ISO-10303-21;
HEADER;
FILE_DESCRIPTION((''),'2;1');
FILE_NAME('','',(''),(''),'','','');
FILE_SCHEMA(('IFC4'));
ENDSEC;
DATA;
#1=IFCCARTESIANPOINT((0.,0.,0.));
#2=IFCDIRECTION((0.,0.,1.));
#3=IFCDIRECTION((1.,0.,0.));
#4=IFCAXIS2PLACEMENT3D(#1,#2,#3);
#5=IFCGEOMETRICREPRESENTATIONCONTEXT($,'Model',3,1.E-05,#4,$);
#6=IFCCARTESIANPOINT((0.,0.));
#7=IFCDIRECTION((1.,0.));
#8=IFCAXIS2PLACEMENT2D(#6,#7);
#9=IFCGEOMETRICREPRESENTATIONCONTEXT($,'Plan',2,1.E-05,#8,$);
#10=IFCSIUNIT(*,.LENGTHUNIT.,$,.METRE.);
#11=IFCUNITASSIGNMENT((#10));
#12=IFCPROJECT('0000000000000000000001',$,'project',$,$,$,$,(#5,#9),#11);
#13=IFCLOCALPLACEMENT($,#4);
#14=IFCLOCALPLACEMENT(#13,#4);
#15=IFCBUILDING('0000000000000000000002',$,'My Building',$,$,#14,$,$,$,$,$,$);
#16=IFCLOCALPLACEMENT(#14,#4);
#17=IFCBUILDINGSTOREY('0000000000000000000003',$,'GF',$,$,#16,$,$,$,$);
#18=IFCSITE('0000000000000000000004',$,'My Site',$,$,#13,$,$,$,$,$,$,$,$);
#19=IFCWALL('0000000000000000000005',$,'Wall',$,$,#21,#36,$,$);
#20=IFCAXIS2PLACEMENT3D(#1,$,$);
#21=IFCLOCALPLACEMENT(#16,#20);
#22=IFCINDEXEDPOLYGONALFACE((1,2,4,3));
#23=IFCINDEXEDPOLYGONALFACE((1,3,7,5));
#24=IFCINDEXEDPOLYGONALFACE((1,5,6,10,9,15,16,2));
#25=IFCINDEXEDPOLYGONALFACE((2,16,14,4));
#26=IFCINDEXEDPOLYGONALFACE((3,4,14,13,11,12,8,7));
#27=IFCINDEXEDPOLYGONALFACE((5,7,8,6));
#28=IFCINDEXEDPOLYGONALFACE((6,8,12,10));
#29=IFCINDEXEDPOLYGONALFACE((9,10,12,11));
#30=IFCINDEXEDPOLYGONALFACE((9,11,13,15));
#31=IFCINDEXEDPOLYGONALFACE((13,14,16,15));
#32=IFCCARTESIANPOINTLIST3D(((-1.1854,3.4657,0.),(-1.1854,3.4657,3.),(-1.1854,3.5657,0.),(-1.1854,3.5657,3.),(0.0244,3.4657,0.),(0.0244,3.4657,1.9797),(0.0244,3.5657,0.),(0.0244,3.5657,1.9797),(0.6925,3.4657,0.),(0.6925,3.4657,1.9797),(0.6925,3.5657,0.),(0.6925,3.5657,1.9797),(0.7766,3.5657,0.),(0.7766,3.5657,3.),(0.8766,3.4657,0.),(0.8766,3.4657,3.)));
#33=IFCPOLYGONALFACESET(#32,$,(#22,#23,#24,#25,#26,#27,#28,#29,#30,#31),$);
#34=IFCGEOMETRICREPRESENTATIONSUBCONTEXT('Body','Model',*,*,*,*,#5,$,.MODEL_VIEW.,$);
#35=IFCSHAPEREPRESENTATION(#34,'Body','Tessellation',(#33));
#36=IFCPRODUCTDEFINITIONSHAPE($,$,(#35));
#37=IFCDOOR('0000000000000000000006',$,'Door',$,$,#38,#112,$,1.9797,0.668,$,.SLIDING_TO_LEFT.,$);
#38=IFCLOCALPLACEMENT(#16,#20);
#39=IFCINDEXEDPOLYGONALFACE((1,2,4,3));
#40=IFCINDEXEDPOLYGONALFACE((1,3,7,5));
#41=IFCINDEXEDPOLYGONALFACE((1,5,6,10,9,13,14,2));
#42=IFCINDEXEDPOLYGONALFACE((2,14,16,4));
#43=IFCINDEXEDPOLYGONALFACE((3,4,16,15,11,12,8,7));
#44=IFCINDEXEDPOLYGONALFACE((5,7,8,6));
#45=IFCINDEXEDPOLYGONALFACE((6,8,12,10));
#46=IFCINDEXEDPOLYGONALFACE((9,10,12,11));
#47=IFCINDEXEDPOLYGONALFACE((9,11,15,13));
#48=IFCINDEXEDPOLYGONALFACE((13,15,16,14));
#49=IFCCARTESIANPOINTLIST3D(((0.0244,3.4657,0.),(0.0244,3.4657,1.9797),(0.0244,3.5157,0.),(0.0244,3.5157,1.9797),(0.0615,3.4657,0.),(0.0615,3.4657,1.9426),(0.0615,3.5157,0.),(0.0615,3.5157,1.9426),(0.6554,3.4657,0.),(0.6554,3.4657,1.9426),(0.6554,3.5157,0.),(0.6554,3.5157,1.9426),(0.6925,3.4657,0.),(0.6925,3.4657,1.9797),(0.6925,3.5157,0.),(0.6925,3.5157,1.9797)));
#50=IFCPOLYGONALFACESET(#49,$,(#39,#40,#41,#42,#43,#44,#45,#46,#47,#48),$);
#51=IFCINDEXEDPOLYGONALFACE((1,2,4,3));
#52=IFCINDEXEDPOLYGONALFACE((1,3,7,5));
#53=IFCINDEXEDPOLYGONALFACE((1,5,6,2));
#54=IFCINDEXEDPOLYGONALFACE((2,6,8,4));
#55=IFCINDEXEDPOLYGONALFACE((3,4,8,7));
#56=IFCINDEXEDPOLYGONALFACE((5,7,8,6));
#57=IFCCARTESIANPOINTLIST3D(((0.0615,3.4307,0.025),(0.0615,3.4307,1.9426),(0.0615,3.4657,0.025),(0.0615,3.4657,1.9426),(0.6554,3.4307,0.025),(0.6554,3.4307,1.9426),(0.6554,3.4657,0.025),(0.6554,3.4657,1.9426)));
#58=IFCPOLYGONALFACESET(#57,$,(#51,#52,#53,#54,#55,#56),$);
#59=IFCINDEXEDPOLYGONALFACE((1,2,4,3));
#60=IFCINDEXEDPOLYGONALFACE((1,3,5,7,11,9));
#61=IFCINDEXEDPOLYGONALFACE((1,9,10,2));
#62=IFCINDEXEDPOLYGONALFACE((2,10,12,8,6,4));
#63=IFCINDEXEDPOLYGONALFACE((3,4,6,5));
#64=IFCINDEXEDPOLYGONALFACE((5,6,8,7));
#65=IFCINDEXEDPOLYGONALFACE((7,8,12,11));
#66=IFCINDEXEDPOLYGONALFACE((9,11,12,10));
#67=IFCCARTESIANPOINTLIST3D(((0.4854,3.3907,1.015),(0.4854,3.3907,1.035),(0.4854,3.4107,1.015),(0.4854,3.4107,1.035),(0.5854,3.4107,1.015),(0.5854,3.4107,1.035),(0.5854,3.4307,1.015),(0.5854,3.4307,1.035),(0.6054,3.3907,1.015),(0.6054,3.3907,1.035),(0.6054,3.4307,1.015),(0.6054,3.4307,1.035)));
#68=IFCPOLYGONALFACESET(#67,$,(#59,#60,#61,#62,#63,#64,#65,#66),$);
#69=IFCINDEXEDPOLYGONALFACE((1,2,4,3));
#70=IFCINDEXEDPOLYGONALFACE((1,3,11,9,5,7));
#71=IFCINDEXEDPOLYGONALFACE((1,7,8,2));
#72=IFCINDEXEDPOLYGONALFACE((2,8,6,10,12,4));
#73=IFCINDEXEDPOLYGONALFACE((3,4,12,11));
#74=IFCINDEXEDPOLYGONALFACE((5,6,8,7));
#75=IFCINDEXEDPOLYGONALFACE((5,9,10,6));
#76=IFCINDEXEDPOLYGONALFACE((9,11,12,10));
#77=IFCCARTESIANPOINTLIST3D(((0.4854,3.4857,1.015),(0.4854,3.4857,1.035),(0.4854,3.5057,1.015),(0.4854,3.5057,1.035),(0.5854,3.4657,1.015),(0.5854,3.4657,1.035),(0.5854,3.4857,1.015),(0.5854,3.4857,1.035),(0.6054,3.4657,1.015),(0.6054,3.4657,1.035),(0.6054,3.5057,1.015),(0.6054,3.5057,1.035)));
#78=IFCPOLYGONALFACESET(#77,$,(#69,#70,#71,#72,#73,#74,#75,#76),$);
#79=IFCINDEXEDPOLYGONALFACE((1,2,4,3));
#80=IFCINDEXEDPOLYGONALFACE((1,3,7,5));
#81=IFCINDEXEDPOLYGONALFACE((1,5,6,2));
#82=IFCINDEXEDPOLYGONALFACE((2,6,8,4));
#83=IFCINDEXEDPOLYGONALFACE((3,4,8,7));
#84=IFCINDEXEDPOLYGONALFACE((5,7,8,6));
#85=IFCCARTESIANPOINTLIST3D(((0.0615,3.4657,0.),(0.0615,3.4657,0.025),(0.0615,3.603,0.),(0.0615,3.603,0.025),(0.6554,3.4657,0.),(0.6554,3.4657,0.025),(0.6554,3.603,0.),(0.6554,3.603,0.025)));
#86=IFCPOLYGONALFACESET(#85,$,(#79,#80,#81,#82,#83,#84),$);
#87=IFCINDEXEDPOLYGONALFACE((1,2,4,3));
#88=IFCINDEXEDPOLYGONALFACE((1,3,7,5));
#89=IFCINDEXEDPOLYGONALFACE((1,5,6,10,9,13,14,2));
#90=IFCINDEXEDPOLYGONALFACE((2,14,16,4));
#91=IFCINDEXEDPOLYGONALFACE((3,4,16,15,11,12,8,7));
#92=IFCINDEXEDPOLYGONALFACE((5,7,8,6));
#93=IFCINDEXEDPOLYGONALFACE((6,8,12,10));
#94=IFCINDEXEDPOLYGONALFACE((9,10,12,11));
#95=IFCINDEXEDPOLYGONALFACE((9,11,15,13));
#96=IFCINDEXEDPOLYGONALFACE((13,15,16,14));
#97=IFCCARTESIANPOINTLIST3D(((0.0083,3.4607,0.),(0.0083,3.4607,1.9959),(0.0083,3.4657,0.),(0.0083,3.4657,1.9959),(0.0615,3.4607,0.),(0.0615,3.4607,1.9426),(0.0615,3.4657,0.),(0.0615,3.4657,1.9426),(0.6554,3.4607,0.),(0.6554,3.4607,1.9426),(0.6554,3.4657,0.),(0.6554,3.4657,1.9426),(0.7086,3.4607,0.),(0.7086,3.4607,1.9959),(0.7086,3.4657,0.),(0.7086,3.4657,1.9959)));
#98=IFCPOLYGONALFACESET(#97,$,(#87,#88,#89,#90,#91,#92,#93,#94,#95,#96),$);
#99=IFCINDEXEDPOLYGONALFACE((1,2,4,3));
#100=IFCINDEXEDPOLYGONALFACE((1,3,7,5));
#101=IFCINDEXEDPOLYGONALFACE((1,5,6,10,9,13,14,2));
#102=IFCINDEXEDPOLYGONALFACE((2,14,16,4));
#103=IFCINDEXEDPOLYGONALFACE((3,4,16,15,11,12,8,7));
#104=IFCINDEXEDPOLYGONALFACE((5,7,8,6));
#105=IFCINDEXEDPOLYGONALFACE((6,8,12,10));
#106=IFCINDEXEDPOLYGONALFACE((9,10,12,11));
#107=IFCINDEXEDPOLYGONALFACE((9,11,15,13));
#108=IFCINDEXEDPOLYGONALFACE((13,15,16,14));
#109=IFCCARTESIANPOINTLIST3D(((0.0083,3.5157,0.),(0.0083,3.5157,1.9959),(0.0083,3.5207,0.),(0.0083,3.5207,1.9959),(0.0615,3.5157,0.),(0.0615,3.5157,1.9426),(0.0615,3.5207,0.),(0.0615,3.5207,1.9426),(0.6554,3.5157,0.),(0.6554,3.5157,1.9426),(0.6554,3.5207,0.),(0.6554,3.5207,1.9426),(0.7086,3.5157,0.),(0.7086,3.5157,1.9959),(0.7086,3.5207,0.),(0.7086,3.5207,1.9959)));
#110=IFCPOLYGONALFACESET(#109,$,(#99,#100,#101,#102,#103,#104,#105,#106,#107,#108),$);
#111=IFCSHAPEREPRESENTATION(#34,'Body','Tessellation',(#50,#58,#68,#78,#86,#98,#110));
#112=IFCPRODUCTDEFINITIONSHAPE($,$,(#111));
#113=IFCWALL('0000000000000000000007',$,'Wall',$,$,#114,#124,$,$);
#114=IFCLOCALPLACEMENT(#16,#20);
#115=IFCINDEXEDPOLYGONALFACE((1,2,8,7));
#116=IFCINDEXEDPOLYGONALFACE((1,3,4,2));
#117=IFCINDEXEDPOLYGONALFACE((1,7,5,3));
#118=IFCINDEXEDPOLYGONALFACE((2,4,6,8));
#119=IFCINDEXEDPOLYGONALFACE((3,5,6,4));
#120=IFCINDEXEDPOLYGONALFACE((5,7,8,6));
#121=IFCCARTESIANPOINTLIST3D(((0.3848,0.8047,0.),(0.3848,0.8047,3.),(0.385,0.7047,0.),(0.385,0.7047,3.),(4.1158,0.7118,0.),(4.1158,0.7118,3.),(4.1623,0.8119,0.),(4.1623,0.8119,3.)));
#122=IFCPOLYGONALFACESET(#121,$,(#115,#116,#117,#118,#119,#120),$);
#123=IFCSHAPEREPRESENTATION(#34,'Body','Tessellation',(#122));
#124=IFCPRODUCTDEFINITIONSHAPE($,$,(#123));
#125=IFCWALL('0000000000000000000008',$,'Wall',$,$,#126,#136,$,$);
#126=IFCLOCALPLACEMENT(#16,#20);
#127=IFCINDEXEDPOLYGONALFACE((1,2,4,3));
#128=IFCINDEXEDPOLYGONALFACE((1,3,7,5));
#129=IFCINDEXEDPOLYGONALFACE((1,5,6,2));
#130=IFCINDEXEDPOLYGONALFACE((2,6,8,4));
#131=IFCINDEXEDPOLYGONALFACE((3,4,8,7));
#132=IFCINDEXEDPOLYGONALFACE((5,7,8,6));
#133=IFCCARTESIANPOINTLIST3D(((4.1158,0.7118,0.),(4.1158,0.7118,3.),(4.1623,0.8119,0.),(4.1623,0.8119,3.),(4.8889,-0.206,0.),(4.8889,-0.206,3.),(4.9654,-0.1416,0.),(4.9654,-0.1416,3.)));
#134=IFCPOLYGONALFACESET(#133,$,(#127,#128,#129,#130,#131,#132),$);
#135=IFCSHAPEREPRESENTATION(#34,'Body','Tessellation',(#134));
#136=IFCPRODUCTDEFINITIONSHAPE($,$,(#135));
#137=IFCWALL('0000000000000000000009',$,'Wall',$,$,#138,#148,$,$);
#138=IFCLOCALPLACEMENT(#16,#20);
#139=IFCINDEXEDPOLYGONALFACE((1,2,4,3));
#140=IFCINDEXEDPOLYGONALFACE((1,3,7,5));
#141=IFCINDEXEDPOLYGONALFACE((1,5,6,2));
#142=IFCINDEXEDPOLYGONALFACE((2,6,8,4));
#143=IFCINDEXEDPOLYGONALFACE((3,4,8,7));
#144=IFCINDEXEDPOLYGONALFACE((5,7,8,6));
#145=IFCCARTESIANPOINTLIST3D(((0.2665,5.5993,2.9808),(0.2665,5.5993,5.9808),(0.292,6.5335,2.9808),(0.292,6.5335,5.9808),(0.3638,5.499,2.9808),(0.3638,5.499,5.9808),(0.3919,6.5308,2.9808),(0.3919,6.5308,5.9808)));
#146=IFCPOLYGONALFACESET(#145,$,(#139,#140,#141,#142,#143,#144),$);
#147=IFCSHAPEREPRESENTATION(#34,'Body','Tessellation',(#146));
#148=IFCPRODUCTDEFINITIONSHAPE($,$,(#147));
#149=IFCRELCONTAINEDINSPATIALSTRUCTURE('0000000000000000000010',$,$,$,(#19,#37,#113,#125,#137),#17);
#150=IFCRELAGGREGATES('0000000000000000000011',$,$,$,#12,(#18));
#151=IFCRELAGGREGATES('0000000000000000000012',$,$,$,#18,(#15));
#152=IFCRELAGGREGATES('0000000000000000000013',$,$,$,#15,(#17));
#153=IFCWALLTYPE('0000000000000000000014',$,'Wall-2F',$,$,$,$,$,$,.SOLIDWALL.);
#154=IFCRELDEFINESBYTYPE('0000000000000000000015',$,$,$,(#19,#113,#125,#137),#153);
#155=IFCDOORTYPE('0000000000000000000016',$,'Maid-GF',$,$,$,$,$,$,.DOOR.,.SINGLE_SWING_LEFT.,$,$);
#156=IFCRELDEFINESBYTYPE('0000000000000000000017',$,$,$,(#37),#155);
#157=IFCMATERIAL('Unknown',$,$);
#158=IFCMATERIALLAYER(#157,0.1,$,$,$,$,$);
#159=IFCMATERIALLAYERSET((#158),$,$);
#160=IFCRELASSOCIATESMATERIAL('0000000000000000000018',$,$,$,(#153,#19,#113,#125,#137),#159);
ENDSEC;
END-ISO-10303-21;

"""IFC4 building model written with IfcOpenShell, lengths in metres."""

from ifc_helpers import new_model, entity, si_unit, frame, origin_with_axes, origin_2d_with_axis, place, context, subcontext, project, spatial, line, indexed_curve, outline, extrude, shape, source, transform, mapped, material, layer, layer_set, layer_usage, type_object, type_shapes, element, fill, save


model = new_model("IFC4")

# Units and contexts
model_context = context("Model", 3, precision=1e-05, world=origin_with_axes())
plan_context = context("Plan", 2, precision=1e-05, world=origin_2d_with_axis())
body_context_1 = subcontext(model_context, "Body", "Model", "MODEL_VIEW")
body_context_2 = subcontext(plan_context, "Body", "Plan", "PLAN_VIEW")
ifc_project = project(units=[si_unit("LENGTHUNIT", "METRE")], contexts=[model_context, plan_context])

# Site, building, storey
site_placement = place(None, origin_with_axes())
site = spatial("IfcSite", under=ifc_project, at=site_placement, Name="My Site")
building_placement = place(site_placement, origin_with_axes())
building = spatial("IfcBuilding", under=site, at=building_placement, Name="My Building")
storey_placement = place(building_placement, origin_with_axes())
storey = spatial("IfcBuildingStorey", under=building, at=storey_placement, Name="GF")

# Shared definitions
ifc_material = material(Name="Unknown")

# Shared definitions
ifc_layer_1 = layer(ifc_material, 0.1)
ifc_layer_set_1 = layer_set([ifc_layer_1])
wall_type = type_object("IfcWallType", Name="Wall-2F", PredefinedType="SOLIDWALL", material=ifc_layer_set_1)

# Wall, opening, door
ifc_layer_usage_1 = layer_usage(ifc_layer_set_1, "AXIS2", "POSITIVE", 0.0)
wall_1_placement = place(storey_placement, frame((0.7766, 3.5657, 0.0), z_axis=(0.0, 0.0, 1.0), x_axis=(-1.0, 0.0, 0.0)))
wall_1 = element("IfcWall", 1, at=wall_1_placement, inside=storey, type_object=wall_type, material=ifc_layer_usage_1, Name="Wall", context=body_context_1, shape_type="SweptSolid", body=[
    extrude(outline(indexed_curve([(0.0, 0.0), (-0.1, 0.1), (1.962, 0.1), (1.962, 0.0)], segments=[line(1, 2, 3, 4, 1)])), origin_with_axes(), (0.0, 0.0, 1.0), 3.0),
])
shared_shape_1 = source(origin_with_axes(), body_context_1, "Body", "SweptSolid", [
    extrude(outline(indexed_curve([(0.0, 0.0), (0.668, 0.0), (0.668, 1.9797), (0.0, 1.9797)], segments=[line(1, 2, 3, 4, 1)])), frame((0.0, -0.6, 0.0), z_axis=(0.0, -1.0, 0.0), x_axis=(1.0, 0.0, 0.0)), (0.0, 0.0, -1.0), 1.2),
])
opening_1_placement = place(wall_1_placement, frame((0.7522, 0.1, 0.0), z_axis=(0.0, 0.0, 1.0), x_axis=(-1.0, 0.0, 0.0)))
opening_1 = element("IfcOpeningElement", 2, at=opening_1_placement, cuts=wall_1, PredefinedType="OPENING", context=body_context_1, shape_type="MappedRepresentation", body=[
    mapped(shared_shape_1, transform((0.0, 0.0, 0.0), x_axis=(1.0, 0.0, 0.0), y_axis=(0.0, 1.0, 0.0), z_axis=(0.0, 0.0, 1.0), scale=1.0)),
])
door_type_1 = type_object("IfcDoorType", Name="Maid-GF", OperationType="SINGLE_SWING_LEFT", PredefinedType="DOOR")
shared_shape_2 = source(origin_with_axes(), body_context_1, "Body", "SweptSolid", [
    extrude(outline(indexed_curve([(0.0, 0.0), (0.0, 1.9797), (0.668, 1.9797), (0.668, 0.0), (0.6309, 0.0), (0.6309, 1.9426), (0.0371, 1.9426), (0.0371, 0.0)], segments=[line(1, 2, 3, 4, 5, 6, 7, 8, 1)])), frame((0.0, 0.0, 0.0), z_axis=(0.0, -1.0, 0.0), x_axis=(1.0, 0.0, 0.0)), (0.0, 0.0, -1.0), 0.05),
    extrude(outline(indexed_curve([(0.0, 0.0), (0.5938, 0.0), (0.5938, 0.035), (0.0, 0.035)], segments=[line(1, 2, 3, 4, 1)])), frame((0.0371, -0.035, 0.025), z_axis=(0.0, 0.0, 1.0), x_axis=(1.0, 0.0, 0.0)), (0.0, 0.0, 1.0), 1.9176),
    extrude(outline(indexed_curve([(0.0, 0.0), (0.0, -0.04), (-0.12, -0.04), (-0.12, -0.02), (-0.02, -0.02), (-0.02, 0.0)], segments=[line(1, 2, 3, 4, 5, 6, 1)])), frame((0.5809, -0.035, 1.015), z_axis=(0.0, 0.0, 1.0), x_axis=(1.0, 0.0, 0.0)), (0.0, 0.0, 1.0), 0.02),
    extrude(outline(indexed_curve([(0.0, 0.0), (0.0, 0.04), (-0.12, 0.04), (-0.12, 0.02), (-0.02, 0.02), (-0.02, 0.0)], segments=[line(1, 2, 3, 4, 5, 6, 1)])), frame((0.5809, 0.0, 1.015), z_axis=(0.0, 0.0, 1.0), x_axis=(1.0, 0.0, 0.0)), (0.0, 0.0, 1.0), 0.02),
    extrude(outline(indexed_curve([(0.0, 0.0), (0.5938, 0.0), (0.5938, 0.1372), (0.0, 0.1372)], segments=[line(1, 2, 3, 4, 1)])), frame((0.0371, 0.0, 0.0), z_axis=(0.0, 0.0, 1.0), x_axis=(1.0, 0.0, 0.0)), (0.0, 0.0, 1.0), 0.025),
    extrude(outline(indexed_curve([(0.0, 0.0), (0.0, 1.9959), (0.7003, 1.9959), (0.7003, 0.0), (0.6471, 0.0), (0.6471, 1.9426), (0.0532, 1.9426), (0.0532, 0.0)], segments=[line(1, 2, 3, 4, 5, 6, 7, 8, 1)])), frame((-0.0162, -0.005, 0.0), z_axis=(0.0, -1.0, 0.0), x_axis=(1.0, 0.0, 0.0)), (0.0, 0.0, -1.0), 0.005),
    extrude(outline(indexed_curve([(0.0, 0.0), (0.0, 1.9959), (0.7003, 1.9959), (0.7003, 0.0), (0.6471, 0.0), (0.6471, 1.9426), (0.0532, 1.9426), (0.0532, 0.0)], segments=[line(1, 2, 3, 4, 5, 6, 7, 8, 1)])), frame((-0.0162, 0.05, 0.0), z_axis=(0.0, -1.0, 0.0), x_axis=(1.0, 0.0, 0.0)), (0.0, 0.0, -1.0), 0.005),
])
shared_shape_3 = source(origin_with_axes(), body_context_2, "Body", "Curve2D", [
    entity("IfcIndexedPolyCurve", entity("IfcCartesianPointList2D", [[0.0, 0.0], [0.0371, 0.0], [0.0371, 0.05], [0.0, 0.05]]), [entity("IfcLineIndex", [1, 2, 3, 4, 1])]),
    entity("IfcIndexedPolyCurve", entity("IfcCartesianPointList2D", [[0.668, 0.0], [0.6309, 0.0], [0.6309, 0.05], [0.668, 0.05]]), [entity("IfcLineIndex", [1, 2, 3, 4, 1])]),
    entity("IfcIndexedPolyCurve", entity("IfcCartesianPointList2D", [[-0.2598, -0.035], [0.334, -0.035], [0.334, 0.0], [-0.2598, 0.0]]), [entity("IfcLineIndex", [1, 2, 3, 4, 1])]),
])
type_shapes(door_type_1, [shared_shape_2, shared_shape_3])
door_1_placement = place(opening_1_placement, origin_with_axes())
door_1 = element("IfcDoor", 3, at=door_1_placement, inside=storey, type_object=door_type_1, Name="Door", OperationType="SLIDING_TO_LEFT", OverallHeight=1.9797, OverallWidth=0.668, shapes=[
    shape(body_context_1, "Body", "MappedRepresentation", [mapped(shared_shape_2, transform((0.0, 0.0, 0.0), x_axis=(1.0, 0.0, 0.0), y_axis=(0.0, 1.0, 0.0), z_axis=(0.0, 0.0, 1.0), scale=1.0))]),
    shape(body_context_2, "Body", "MappedRepresentation", [mapped(shared_shape_3, transform((0.0, 0.0, 0.0), x_axis=(1.0, 0.0, 0.0), y_axis=(0.0, 1.0, 0.0), z_axis=(0.0, 0.0, 1.0), scale=1.0))]),
])
fill(opening_1, door_1)

# Walls
ifc_layer_usage_2 = layer_usage(ifc_layer_set_1, "AXIS2", "POSITIVE", 0.0)
wall_2_placement = place(storey_placement, frame((0.385, 0.7047, 0.0), z_axis=(0.0, 0.0, 1.0), x_axis=(0.999998, 0.001891, 0.0)))
element("IfcWall", 4, at=wall_2_placement, inside=storey, type_object=wall_type, material=ifc_layer_usage_2, Name="Wall", context=body_context_1, shape_type="SweptSolid", body=[
    extrude(outline(indexed_curve([(0.0, 0.0), (0.0, 0.1), (3.7774, 0.1), (3.7308, 0.0)], segments=[line(1, 2, 3, 4, 1)])), origin_with_axes(), (0.0, 0.0, 1.0), 3.0),
])
ifc_layer_usage_3 = layer_usage(ifc_layer_set_1, "AXIS2", "POSITIVE", 0.0)
wall_3_placement = place(storey_placement, frame((4.1158, 0.7118, 0.0), z_axis=(0.0, 0.0, 1.0), x_axis=(0.644235, -0.764827, 0.0)))
element("IfcWall", 5, at=wall_3_placement, inside=storey, type_object=wall_type, material=ifc_layer_usage_3, Name="Wall", context=body_context_1, shape_type="SweptSolid", body=[
    extrude(outline(indexed_curve([(0.0, 0.0), (-0.0466, 0.1), (1.2, 0.1), (1.2, 0.0)], segments=[line(1, 2, 3, 4, 1)])), origin_with_axes(), (0.0, 0.0, 1.0), 3.0),
])
ifc_layer_usage_4 = layer_usage(ifc_layer_set_1, "AXIS2", "POSITIVE", 0.0)
wall_4_placement = place(storey_placement, frame((0.292, 6.5335, 2.9808), z_axis=(0.0, 0.0, 1.0), x_axis=(-0.027264, -0.999628, 0.0)))
element("IfcWall", 6, at=wall_4_placement, inside=storey, type_object=wall_type, material=ifc_layer_usage_4, Name="Wall", context=body_context_1, shape_type="SweptSolid", body=[
    extrude(outline(indexed_curve([(0.0, 0.0), (0.0, 0.1), (1.0322, 0.1), (0.9346, 0.0)], segments=[line(1, 2, 3, 4, 1)])), origin_with_axes(), (0.0, 0.0, 1.0), 3.0),
])

save(model, "model.ifc")
